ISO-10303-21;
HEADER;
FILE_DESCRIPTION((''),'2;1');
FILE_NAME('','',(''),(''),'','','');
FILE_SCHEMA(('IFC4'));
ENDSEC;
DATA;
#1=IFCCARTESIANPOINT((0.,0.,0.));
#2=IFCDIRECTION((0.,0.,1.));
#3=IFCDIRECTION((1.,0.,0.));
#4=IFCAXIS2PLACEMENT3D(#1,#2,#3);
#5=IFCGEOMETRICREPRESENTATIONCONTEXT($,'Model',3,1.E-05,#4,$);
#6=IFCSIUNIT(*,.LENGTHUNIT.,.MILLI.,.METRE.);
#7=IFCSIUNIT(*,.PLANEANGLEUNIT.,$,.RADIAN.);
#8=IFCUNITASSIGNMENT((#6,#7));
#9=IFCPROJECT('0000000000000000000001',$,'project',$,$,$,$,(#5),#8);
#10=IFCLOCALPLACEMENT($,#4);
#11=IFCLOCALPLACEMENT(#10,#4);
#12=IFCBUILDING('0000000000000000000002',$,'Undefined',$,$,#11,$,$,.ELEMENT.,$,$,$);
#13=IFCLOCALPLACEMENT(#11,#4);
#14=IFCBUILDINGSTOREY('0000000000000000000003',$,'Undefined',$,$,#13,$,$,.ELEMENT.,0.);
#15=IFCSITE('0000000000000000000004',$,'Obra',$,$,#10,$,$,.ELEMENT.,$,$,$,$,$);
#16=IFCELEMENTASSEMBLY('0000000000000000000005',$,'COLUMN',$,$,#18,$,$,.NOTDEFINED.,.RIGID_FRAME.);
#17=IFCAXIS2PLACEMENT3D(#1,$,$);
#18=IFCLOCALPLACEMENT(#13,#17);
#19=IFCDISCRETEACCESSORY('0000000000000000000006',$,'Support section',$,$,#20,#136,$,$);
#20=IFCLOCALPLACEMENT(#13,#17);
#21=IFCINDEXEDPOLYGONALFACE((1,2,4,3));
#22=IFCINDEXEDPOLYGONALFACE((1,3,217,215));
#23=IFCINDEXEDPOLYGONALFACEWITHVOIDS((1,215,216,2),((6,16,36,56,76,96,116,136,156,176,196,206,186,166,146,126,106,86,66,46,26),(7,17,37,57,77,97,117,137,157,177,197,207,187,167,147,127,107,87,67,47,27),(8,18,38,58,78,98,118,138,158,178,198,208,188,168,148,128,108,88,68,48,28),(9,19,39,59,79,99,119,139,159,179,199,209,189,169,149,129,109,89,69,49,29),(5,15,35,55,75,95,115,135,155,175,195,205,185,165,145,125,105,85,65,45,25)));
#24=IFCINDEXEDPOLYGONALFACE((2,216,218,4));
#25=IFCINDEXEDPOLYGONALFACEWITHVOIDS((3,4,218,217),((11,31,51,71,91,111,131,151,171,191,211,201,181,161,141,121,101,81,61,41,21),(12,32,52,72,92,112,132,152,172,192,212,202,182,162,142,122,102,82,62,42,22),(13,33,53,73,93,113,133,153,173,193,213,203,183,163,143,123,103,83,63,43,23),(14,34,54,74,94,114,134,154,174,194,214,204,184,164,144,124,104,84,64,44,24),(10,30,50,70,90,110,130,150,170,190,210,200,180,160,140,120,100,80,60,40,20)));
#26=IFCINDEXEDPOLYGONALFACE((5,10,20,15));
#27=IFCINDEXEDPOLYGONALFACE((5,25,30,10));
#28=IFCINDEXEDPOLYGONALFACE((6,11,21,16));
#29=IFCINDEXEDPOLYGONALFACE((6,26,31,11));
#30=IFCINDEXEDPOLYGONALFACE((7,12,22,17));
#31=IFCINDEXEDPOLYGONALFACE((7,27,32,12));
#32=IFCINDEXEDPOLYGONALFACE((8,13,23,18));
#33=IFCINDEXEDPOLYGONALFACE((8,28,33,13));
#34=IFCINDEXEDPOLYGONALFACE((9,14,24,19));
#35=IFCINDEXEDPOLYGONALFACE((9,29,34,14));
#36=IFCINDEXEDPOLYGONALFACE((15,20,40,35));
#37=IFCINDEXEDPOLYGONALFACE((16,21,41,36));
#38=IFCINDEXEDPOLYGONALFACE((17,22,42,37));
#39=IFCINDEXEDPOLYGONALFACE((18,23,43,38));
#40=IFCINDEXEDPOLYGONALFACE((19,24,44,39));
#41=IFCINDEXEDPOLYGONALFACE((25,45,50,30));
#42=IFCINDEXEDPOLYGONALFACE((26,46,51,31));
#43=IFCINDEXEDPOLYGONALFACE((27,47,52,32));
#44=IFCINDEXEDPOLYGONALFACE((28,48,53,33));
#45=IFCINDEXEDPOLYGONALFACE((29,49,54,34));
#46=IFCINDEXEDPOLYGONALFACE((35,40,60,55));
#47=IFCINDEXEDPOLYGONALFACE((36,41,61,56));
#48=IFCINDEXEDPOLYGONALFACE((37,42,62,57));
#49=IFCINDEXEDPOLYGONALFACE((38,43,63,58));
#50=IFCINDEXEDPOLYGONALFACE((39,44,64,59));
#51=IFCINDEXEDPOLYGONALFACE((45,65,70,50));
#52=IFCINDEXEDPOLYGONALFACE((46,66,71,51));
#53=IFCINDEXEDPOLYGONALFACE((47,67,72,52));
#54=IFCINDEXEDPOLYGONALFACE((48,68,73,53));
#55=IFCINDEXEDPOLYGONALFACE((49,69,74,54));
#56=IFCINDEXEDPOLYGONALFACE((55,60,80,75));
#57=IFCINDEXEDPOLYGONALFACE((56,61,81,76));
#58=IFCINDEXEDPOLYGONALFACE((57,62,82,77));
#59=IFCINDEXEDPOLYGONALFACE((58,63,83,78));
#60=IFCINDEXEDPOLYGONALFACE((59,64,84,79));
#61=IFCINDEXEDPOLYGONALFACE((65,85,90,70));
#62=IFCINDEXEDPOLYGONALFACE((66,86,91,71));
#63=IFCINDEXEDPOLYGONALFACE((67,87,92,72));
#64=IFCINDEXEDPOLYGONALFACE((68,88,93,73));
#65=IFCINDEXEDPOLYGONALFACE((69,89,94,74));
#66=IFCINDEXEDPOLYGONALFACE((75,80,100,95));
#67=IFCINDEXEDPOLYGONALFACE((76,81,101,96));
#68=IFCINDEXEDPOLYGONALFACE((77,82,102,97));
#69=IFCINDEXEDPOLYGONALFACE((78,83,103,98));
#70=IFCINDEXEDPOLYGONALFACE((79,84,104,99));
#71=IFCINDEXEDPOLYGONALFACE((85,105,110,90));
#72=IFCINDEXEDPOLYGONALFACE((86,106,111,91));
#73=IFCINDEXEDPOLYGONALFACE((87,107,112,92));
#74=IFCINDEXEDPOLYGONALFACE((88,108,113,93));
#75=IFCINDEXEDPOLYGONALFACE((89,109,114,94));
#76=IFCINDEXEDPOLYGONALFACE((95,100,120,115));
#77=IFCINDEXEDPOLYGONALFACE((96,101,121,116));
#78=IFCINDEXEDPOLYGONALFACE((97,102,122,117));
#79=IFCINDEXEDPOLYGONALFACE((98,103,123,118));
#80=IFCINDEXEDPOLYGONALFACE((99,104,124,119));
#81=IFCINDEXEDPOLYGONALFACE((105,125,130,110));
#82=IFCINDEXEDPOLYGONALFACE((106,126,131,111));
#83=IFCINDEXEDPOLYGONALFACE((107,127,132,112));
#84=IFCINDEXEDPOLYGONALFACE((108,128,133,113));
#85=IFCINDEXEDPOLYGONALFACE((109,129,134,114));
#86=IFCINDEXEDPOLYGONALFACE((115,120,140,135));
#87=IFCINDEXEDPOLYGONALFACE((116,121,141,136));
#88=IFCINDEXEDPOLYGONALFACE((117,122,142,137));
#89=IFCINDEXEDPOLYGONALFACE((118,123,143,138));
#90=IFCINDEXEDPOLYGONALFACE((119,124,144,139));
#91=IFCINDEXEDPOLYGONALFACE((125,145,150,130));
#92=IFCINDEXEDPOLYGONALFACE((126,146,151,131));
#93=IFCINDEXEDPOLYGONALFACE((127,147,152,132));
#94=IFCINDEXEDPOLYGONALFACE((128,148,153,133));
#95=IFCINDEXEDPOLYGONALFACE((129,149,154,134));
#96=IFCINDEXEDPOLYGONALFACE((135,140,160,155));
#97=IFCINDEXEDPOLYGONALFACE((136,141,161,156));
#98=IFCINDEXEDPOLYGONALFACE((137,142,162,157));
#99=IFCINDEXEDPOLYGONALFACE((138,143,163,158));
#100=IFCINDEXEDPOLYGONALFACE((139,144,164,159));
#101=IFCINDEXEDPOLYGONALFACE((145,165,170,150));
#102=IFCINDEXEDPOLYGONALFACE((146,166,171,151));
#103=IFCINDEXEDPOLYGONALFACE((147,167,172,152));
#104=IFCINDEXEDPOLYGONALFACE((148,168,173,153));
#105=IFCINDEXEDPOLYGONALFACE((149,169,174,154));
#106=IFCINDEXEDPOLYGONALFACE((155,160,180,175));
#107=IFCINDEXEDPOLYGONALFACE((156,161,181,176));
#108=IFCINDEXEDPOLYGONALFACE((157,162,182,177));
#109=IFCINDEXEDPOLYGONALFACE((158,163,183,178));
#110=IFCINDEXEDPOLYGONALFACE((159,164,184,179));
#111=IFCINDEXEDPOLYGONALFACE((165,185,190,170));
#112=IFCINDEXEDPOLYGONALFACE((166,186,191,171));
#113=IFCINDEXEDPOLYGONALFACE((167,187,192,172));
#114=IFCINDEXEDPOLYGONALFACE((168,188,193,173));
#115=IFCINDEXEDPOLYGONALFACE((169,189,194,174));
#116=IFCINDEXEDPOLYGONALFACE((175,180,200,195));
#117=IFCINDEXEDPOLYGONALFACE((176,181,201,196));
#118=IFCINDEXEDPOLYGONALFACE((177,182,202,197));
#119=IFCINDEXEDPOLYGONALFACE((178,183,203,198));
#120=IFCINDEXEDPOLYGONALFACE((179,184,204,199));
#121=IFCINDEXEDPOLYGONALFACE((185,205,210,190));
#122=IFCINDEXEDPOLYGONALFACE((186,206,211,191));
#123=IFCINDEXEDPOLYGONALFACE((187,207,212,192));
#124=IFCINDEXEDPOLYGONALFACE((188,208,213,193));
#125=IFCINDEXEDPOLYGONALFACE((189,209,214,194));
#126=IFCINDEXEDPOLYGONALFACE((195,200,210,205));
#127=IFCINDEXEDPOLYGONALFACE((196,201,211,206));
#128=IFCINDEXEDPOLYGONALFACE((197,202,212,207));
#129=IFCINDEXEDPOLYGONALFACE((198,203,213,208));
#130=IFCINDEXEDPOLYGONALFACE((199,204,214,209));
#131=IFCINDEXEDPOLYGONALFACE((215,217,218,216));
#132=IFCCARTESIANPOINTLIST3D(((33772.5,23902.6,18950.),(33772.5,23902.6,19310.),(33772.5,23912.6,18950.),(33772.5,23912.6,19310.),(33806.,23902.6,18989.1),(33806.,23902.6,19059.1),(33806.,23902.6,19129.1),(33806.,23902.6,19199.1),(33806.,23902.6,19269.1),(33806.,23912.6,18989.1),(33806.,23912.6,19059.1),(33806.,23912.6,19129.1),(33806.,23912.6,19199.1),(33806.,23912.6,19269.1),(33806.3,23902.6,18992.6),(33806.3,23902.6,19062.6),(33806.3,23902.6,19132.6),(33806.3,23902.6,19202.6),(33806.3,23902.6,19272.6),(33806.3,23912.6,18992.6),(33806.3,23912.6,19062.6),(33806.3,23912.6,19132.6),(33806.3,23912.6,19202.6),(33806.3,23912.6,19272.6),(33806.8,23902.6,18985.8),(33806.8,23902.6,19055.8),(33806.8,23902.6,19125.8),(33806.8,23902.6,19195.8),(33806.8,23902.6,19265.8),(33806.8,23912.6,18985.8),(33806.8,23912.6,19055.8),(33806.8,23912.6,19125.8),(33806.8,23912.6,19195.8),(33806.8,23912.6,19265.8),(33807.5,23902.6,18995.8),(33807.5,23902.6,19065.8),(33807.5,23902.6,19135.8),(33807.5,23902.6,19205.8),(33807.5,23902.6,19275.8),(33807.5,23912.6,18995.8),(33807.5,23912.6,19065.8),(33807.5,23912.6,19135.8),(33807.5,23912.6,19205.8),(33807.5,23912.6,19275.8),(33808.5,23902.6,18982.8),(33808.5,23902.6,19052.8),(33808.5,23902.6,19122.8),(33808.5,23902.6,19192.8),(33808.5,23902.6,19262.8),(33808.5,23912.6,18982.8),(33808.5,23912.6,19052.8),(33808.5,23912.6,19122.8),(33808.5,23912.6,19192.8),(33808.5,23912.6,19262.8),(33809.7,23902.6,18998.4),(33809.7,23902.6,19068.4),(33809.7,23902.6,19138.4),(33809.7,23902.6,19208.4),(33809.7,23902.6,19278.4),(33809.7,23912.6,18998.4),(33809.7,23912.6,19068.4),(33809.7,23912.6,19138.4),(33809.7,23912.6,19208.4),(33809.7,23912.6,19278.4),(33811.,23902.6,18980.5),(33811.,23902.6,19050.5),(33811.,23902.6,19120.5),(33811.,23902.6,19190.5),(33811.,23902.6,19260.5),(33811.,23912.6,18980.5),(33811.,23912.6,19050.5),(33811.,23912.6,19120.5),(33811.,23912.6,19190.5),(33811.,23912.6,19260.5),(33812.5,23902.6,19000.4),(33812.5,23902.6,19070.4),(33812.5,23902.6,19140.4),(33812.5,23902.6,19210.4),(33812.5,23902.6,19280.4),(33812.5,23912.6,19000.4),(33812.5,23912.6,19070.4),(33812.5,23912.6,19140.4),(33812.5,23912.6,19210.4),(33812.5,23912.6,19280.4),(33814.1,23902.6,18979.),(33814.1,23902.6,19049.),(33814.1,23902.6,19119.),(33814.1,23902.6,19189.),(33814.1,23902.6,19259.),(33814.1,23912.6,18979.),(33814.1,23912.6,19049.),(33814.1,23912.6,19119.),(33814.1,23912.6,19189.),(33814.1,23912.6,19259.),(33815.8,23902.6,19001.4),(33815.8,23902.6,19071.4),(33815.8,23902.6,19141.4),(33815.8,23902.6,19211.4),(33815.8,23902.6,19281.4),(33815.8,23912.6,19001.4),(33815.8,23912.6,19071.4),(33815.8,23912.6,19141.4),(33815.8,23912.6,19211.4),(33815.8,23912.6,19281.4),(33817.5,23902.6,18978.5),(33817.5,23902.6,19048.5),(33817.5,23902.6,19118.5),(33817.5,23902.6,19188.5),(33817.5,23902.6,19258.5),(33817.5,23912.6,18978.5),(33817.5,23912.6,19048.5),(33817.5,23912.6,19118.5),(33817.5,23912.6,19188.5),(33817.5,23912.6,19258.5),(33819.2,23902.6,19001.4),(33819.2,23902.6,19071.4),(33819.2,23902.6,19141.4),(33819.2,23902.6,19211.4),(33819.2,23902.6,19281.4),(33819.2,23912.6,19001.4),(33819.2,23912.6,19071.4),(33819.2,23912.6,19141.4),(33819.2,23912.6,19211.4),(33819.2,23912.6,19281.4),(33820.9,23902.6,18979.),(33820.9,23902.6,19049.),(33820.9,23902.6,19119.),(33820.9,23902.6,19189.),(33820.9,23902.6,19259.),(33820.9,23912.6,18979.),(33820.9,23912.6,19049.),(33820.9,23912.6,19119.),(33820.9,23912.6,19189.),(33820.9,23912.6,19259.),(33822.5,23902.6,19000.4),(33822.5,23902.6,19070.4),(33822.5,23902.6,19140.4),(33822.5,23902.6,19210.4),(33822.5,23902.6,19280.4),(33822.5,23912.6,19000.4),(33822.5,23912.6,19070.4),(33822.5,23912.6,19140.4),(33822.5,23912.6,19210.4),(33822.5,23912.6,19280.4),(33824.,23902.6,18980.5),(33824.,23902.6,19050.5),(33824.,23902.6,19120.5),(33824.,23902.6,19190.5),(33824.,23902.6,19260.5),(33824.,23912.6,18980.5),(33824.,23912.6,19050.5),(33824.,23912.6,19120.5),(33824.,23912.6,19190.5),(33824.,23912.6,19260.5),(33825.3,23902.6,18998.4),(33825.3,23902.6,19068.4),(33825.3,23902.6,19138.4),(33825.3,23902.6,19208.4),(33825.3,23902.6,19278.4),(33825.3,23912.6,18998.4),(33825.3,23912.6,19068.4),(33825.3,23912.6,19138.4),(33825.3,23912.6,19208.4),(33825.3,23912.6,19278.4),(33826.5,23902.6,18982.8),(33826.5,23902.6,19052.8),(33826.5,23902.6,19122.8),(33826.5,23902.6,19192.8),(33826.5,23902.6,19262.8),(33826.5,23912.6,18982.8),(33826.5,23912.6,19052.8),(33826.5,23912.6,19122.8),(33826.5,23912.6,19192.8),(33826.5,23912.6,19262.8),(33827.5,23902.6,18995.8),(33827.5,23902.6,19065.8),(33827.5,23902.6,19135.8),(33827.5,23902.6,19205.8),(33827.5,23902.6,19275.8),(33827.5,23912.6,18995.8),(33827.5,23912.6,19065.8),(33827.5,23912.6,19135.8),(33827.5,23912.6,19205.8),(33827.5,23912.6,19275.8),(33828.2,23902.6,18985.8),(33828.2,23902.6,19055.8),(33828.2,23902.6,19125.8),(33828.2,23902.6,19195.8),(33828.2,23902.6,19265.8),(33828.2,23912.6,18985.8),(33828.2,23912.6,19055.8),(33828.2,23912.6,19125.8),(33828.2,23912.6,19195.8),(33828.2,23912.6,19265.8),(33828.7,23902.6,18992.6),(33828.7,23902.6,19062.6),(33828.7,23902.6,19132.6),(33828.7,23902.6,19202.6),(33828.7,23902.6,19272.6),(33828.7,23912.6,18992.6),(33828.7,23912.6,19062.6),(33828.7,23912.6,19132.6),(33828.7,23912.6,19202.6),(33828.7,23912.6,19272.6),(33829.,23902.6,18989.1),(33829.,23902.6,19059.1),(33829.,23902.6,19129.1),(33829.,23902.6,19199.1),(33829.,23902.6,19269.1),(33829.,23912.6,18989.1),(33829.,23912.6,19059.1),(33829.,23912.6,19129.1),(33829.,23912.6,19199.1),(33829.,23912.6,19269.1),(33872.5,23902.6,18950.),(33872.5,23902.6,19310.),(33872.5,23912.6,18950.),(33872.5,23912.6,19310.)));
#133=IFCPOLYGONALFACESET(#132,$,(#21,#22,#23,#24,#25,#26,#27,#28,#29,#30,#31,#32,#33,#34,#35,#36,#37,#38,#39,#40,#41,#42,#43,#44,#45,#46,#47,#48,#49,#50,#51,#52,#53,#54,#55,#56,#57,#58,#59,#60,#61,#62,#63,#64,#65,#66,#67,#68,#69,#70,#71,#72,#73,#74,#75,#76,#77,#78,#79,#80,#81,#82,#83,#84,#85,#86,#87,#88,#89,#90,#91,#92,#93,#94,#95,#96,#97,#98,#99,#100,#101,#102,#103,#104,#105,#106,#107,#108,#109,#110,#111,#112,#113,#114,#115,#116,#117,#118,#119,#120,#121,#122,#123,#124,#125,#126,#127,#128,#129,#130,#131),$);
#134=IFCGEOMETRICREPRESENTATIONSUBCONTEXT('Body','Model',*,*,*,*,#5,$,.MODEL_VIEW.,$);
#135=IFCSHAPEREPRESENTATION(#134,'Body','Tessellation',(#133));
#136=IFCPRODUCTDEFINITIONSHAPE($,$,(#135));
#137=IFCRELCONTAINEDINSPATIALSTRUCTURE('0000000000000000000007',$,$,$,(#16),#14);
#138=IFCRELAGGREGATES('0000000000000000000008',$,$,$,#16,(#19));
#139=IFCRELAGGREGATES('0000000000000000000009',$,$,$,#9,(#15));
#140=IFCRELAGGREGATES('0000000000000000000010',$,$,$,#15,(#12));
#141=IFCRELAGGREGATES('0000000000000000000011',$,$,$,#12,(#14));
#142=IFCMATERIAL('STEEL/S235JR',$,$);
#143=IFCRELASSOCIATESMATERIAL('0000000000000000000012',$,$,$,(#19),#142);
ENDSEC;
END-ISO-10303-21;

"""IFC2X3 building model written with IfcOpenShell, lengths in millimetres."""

from ifc_helpers import new_model, si_unit, frame, origin_with_axes, origin_2d_with_axis, place, context, subcontext, project, spatial, rectangle, circle, extrude, source, transform, mapped, material, element, aggregate, save


model = new_model("IFC2X3")

# Units and contexts
model_context = context("Model", 3, precision=1e-05, world=origin_with_axes())
body_context = subcontext(model_context, "Body", "Model", "MODEL_VIEW")
ifc_project = project(units=[si_unit("LENGTHUNIT", "METRE", prefix="MILLI"), si_unit("PLANEANGLEUNIT", "RADIAN")], contexts=[model_context])

# Site, building, storey
site_placement = place(None, origin_with_axes())
site = spatial("IfcSite", under=ifc_project, at=site_placement, Name="Obra", CompositionType="ELEMENT")
building_placement = place(site_placement, origin_with_axes())
building = spatial("IfcBuilding", under=site, at=building_placement, Name="Undefined", CompositionType="ELEMENT")
storey_placement = place(building_placement, origin_with_axes())
storey = spatial("IfcBuildingStorey", under=building, at=storey_placement, Name="Undefined", CompositionType="ELEMENT", Elevation=0.0)

# Element assembly
assembly_1_placement = place(storey_placement, origin_with_axes())
assembly_1 = element("IfcElementAssembly", 1, at=assembly_1_placement, inside=storey, Name="COLUMN", AssemblyPlace="NOTDEFINED", PredefinedType="RIGID_FRAME")
ifc_material_1 = material(Name="STEEL/S235JR")

# Discrete accessory, opening
discrete_accessory_1_placement = place(assembly_1_placement, frame((33822.5, 23907.6, 18950.0), z_axis=(0.0, 0.0, 1.0), x_axis=(1.0, 0.0, 0.0)))
discrete_accessory_1 = element("IfcDiscreteAccessory", 2, at=discrete_accessory_1_placement, material=ifc_material_1, Name="Support section", context=body_context, shape_type="SweptSolid", body=[
    extrude(rectangle(XDim=10.0, YDim=100.0, at=origin_2d_with_axis()), frame((0.0, 0.0, 360.0), z_axis=(0.0, 0.0, -1.0), x_axis=(0.0, 1.0, 0.0)), (0.0, 0.0, 1.0), 360.0),
])
shared_shape_1 = source(origin_with_axes(), body_context, "Body", "SweptSolid", [
    extrude(circle(Radius=11.5, at=origin_2d_with_axis()), frame((0.0, -15.8, 0.0), z_axis=(0.0, 1.0, 0.0), x_axis=(1.0, 0.0, 0.0)), (0.0, 0.0, 1.0), 10.2),
])
opening_1_placement = place(assembly_1_placement, frame((33862.5, 23896.9, 19350.0), z_axis=(-1.0, 0.0, 0.0), x_axis=(0.0, 0.0, -1.0)))
element("IfcOpeningElement", 3, at=opening_1_placement, cuts=discrete_accessory_1, ObjectType="Opening", context=body_context, shape_type="MappedRepresentation", body=[
    mapped(shared_shape_1, transform((80.0, 0.0, 45.0))),
    mapped(shared_shape_1, transform((150.0, 0.0, 45.0))),
    mapped(shared_shape_1, transform((220.0, 0.0, 45.0))),
    mapped(shared_shape_1, transform((290.0, 0.0, 45.0))),
    mapped(shared_shape_1, transform((360.0, 0.0, 45.0))),
])
aggregate(assembly_1, [discrete_accessory_1])

save(model, "model.ifc")
